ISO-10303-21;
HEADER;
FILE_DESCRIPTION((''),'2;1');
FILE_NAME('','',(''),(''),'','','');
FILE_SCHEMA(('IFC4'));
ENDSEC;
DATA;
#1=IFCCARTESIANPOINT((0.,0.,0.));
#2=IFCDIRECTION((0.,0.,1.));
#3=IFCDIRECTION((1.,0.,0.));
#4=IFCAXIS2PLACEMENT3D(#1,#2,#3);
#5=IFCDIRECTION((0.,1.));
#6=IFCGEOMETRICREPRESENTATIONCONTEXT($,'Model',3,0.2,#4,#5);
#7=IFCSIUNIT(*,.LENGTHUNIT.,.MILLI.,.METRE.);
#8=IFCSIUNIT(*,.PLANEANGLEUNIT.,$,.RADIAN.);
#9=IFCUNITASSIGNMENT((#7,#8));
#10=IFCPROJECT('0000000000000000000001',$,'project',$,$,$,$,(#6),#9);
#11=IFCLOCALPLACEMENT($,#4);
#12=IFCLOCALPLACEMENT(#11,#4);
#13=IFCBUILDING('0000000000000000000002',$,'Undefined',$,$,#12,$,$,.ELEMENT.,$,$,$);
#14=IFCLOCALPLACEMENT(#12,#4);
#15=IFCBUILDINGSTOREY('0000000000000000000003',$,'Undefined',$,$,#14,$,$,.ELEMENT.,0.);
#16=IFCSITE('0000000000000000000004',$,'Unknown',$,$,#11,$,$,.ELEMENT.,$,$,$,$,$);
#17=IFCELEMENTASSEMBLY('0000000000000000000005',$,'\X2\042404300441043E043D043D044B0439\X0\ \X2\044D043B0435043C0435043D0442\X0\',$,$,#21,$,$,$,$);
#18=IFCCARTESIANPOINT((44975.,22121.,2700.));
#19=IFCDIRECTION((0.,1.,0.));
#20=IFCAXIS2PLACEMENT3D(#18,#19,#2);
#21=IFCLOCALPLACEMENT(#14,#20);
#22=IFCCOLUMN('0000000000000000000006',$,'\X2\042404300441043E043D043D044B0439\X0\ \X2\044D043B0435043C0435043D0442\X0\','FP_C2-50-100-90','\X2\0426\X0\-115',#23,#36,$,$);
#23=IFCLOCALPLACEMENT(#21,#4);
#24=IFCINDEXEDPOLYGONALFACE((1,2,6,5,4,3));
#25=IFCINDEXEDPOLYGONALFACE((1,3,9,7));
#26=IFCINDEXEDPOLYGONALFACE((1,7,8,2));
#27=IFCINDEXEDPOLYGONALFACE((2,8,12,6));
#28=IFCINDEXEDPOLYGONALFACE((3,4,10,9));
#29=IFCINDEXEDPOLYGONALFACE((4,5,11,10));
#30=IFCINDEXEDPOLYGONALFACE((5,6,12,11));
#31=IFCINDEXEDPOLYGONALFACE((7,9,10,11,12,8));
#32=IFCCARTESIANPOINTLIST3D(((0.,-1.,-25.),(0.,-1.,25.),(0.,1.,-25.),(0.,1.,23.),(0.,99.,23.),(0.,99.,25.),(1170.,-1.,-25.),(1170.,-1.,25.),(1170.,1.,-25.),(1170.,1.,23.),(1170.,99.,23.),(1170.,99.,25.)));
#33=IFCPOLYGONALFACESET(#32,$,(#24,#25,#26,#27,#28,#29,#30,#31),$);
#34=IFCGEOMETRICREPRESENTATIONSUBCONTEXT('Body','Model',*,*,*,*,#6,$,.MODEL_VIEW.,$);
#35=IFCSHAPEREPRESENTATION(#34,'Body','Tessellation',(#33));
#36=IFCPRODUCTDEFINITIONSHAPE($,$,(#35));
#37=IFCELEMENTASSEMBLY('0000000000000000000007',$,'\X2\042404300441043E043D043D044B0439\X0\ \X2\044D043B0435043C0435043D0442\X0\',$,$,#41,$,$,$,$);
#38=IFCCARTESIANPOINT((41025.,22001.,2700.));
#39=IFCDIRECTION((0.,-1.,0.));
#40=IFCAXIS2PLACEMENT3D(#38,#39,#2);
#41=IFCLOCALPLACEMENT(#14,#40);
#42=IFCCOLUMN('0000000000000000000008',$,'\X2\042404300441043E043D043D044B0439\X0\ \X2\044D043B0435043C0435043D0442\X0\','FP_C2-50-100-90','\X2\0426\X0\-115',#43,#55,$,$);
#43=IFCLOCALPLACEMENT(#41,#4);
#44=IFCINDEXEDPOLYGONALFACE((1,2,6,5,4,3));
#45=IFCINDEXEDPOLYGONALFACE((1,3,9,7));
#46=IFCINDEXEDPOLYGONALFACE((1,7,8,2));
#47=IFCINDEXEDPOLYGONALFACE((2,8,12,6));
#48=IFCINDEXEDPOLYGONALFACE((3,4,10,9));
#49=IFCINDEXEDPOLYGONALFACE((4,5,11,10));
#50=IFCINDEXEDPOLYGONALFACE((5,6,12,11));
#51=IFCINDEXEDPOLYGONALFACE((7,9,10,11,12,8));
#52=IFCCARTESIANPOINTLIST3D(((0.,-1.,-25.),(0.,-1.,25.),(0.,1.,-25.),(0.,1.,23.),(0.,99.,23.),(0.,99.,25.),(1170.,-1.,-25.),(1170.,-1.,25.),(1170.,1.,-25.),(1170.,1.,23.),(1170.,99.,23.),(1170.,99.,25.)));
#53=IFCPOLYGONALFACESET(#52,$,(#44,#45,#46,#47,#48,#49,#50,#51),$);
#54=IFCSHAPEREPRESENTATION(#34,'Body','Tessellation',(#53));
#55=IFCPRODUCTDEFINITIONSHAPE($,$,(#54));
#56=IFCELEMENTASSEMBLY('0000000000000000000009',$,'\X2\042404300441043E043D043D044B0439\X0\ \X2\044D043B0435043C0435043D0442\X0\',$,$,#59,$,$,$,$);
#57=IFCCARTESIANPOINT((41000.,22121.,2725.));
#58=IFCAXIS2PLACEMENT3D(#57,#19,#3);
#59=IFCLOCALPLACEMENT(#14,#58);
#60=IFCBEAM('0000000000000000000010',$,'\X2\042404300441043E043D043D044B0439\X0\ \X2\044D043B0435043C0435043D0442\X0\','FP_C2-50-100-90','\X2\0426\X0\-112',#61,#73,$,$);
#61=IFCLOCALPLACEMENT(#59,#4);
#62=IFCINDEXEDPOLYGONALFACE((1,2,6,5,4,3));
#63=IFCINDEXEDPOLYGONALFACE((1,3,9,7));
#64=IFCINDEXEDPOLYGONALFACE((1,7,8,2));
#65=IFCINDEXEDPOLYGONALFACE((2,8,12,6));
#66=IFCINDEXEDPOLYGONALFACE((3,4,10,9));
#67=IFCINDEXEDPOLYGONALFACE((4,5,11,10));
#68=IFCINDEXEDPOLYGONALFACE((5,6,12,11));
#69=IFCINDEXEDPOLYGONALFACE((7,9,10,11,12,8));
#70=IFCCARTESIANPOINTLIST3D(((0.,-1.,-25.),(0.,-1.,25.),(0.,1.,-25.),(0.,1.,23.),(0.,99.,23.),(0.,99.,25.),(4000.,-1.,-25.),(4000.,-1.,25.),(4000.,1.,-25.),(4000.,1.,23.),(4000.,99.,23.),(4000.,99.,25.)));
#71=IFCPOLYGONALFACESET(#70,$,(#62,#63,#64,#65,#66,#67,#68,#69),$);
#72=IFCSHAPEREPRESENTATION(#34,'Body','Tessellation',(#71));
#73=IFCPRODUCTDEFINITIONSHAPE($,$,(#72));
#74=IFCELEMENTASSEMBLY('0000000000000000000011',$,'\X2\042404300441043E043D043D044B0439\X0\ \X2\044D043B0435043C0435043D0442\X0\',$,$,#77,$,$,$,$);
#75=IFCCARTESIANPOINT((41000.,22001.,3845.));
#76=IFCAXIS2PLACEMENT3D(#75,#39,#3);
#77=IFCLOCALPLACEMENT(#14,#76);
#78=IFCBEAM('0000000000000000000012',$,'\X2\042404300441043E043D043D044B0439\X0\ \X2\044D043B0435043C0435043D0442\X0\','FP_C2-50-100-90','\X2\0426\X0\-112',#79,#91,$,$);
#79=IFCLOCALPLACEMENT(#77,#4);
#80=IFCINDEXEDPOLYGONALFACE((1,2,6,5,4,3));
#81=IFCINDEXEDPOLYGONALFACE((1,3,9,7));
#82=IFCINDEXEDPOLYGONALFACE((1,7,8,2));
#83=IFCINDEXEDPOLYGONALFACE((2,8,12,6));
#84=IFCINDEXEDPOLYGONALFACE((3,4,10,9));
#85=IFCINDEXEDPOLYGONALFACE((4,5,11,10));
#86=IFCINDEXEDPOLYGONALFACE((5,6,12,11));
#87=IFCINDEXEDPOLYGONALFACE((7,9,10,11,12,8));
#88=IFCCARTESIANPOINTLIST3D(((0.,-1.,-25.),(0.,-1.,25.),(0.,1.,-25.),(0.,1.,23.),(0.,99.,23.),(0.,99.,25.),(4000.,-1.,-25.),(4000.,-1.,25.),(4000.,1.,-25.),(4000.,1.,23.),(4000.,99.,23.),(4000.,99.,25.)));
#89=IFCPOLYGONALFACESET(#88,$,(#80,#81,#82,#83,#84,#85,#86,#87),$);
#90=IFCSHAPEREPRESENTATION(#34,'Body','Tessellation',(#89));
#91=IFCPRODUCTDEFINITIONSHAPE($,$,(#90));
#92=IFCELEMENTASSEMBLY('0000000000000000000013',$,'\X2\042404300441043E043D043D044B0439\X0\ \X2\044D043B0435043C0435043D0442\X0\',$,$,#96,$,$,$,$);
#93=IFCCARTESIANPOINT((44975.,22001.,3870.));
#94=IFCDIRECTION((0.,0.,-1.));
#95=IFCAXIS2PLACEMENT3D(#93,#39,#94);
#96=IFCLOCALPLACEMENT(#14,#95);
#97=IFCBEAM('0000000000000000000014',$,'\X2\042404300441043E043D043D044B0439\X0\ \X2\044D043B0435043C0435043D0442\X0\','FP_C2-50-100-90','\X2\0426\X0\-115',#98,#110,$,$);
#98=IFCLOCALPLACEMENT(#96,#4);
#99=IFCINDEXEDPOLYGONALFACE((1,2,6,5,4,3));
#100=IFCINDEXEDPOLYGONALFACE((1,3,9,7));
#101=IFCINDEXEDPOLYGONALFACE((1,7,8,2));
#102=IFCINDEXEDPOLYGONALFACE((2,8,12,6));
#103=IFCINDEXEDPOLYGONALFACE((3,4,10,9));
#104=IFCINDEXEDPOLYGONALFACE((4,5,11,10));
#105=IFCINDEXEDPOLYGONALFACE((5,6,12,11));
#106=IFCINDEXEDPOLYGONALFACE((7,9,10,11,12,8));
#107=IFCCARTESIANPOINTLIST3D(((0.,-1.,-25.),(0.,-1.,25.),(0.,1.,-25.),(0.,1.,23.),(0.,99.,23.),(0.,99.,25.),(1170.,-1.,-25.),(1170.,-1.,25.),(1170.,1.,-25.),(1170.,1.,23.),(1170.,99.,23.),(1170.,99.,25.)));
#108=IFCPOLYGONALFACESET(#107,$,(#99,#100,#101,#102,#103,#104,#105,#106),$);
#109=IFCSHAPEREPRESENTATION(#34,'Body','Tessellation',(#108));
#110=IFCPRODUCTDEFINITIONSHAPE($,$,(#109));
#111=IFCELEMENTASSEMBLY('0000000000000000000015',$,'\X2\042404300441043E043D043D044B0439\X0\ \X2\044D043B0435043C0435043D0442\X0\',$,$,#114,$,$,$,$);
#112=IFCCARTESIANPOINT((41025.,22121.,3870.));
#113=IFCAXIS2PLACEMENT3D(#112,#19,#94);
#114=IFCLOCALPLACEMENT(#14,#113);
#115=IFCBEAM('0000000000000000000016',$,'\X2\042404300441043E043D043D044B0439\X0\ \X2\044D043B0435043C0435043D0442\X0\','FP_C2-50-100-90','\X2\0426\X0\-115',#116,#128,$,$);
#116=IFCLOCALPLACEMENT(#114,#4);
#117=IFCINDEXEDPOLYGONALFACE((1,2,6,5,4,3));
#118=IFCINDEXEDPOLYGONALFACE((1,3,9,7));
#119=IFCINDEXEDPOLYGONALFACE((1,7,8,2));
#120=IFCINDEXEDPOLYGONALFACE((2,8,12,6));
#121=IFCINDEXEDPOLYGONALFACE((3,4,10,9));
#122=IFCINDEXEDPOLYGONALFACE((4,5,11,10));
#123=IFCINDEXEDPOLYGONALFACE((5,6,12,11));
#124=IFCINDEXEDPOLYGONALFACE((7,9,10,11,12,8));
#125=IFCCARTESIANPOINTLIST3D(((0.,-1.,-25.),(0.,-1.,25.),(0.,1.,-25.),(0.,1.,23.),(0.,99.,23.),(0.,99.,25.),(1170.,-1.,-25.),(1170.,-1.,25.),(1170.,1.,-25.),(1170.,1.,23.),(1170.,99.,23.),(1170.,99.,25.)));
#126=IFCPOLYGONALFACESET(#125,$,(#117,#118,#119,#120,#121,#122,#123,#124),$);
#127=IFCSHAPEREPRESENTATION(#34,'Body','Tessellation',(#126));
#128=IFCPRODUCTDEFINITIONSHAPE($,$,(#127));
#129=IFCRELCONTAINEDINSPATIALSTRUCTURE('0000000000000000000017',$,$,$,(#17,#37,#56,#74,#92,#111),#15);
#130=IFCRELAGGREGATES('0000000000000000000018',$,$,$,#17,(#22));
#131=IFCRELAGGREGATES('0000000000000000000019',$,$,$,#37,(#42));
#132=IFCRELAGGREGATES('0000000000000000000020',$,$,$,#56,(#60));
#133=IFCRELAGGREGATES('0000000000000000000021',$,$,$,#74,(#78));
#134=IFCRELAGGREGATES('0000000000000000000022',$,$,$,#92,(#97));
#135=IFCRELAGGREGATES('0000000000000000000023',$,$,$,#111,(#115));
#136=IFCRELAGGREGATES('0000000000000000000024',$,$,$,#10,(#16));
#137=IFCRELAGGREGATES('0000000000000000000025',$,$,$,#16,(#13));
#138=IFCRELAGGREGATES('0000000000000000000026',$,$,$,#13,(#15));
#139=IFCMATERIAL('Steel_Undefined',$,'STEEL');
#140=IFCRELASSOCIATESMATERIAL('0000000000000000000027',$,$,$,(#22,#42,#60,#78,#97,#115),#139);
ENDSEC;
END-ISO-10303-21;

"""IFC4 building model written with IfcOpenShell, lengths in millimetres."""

from ifc_helpers import new_model, si_unit, direction, frame, origin_with_axes, place, context, subcontext, project, spatial, line, indexed_curve, outline, extrude, material, element, aggregate, save


model = new_model("IFC4")

# Units and contexts
model_context = context("Model", 3, precision=0.2, world=origin_with_axes(), true_north=direction((0.0, 1.0)))
body_context = subcontext(model_context, "Body", "Model", "MODEL_VIEW")
ifc_project = project(units=[si_unit("LENGTHUNIT", "METRE", prefix="MILLI"), si_unit("PLANEANGLEUNIT", "RADIAN")], contexts=[model_context])

# Site, building, storey
site_placement = place(None, origin_with_axes())
site = spatial("IfcSite", under=ifc_project, at=site_placement, Name="Unknown", CompositionType="ELEMENT")
building_placement = place(site_placement, origin_with_axes())
building = spatial("IfcBuilding", under=site, at=building_placement, Name="Undefined", CompositionType="ELEMENT")
storey_placement = place(building_placement, origin_with_axes())
storey = spatial("IfcBuildingStorey", under=building, at=storey_placement, Name="Undefined", CompositionType="ELEMENT", Elevation=0.0)

# Element assemblies, columns
assembly_1_placement = place(storey_placement, frame((44975.0, 22121.0, 2700.0), z_axis=(0.0, 1.0, 0.0), x_axis=(0.0, 0.0, 1.0)))
assembly_1 = element("IfcElementAssembly", 1, at=assembly_1_placement, inside=storey, Name="Фасонный элемент")
ifc_material_1 = material(Name="Steel_Undefined", Category="STEEL")
column_1_placement = place(assembly_1_placement, origin_with_axes())
column_1 = element("IfcColumn", 2, at=column_1_placement, material=ifc_material_1, Name="Фасонный элемент", Description="FP_C2-50-100-90", ObjectType="Ц-115", context=body_context, shape_type="SolidModel", body=[
    extrude(outline(indexed_curve([(-25.0, -1.0), (25.0, -1.0), (25.0, 99.0), (23.0, 99.0), (23.0, 1.0), (-25.0, 1.0)], segments=[line(1, 2, 3, 4, 5, 6, 1)])), frame((0.0, 0.0, 0.0), z_axis=(-1.0, 0.0, 0.0), x_axis=(0.0, 0.0, 1.0)), (0.0, 0.0, -1.0), 1170.0),
])
aggregate(assembly_1, [column_1])
assembly_2_placement = place(storey_placement, frame((41025.0, 22001.0, 2700.0), z_axis=(0.0, -1.0, 0.0), x_axis=(0.0, 0.0, 1.0)))
assembly_2 = element("IfcElementAssembly", 3, at=assembly_2_placement, inside=storey, Name="Фасонный элемент")
column_2_placement = place(assembly_2_placement, origin_with_axes())
column_2 = element("IfcColumn", 4, at=column_2_placement, material=ifc_material_1, Name="Фасонный элемент", Description="FP_C2-50-100-90", ObjectType="Ц-115", context=body_context, shape_type="SolidModel", body=[
    extrude(outline(indexed_curve([(-25.0, -1.0), (25.0, -1.0), (25.0, 99.0), (23.0, 99.0), (23.0, 1.0), (-25.0, 1.0)], segments=[line(1, 2, 3, 4, 5, 6, 1)])), frame((0.0, 0.0, 0.0), z_axis=(-1.0, 0.0, 0.0), x_axis=(0.0, 0.0, 1.0)), (0.0, 0.0, -1.0), 1170.0),
])
aggregate(assembly_2, [column_2])

# Element assemblies, beams
assembly_3_placement = place(storey_placement, frame((41000.0, 22121.0, 2725.0), z_axis=(0.0, 1.0, 0.0), x_axis=(1.0, 0.0, 0.0)))
assembly_3 = element("IfcElementAssembly", 5, at=assembly_3_placement, inside=storey, Name="Фасонный элемент")
beam_1_placement = place(assembly_3_placement, origin_with_axes())
beam_1 = element("IfcBeam", 6, at=beam_1_placement, material=ifc_material_1, Name="Фасонный элемент", Description="FP_C2-50-100-90", ObjectType="Ц-112", context=body_context, shape_type="SolidModel", body=[
    extrude(outline(indexed_curve([(-25.0, -1.0), (25.0, -1.0), (25.0, 99.0), (23.0, 99.0), (23.0, 1.0), (-25.0, 1.0)], segments=[line(1, 2, 3, 4, 5, 6, 1)])), frame((0.0, 0.0, 0.0), z_axis=(-1.0, 0.0, 0.0), x_axis=(0.0, 0.0, 1.0)), (0.0, 0.0, -1.0), 4000.0),
])
aggregate(assembly_3, [beam_1])
assembly_4_placement = place(storey_placement, frame((41000.0, 22001.0, 3845.0), z_axis=(0.0, -1.0, 0.0), x_axis=(1.0, 0.0, 0.0)))
assembly_4 = element("IfcElementAssembly", 7, at=assembly_4_placement, inside=storey, Name="Фасонный элемент")
beam_2_placement = place(assembly_4_placement, origin_with_axes())
beam_2 = element("IfcBeam", 8, at=beam_2_placement, material=ifc_material_1, Name="Фасонный элемент", Description="FP_C2-50-100-90", ObjectType="Ц-112", context=body_context, shape_type="SolidModel", body=[
    extrude(outline(indexed_curve([(-25.0, -1.0), (25.0, -1.0), (25.0, 99.0), (23.0, 99.0), (23.0, 1.0), (-25.0, 1.0)], segments=[line(1, 2, 3, 4, 5, 6, 1)])), frame((0.0, 0.0, 0.0), z_axis=(-1.0, 0.0, 0.0), x_axis=(0.0, 0.0, 1.0)), (0.0, 0.0, -1.0), 4000.0),
])
aggregate(assembly_4, [beam_2])
assembly_5_placement = place(storey_placement, frame((44975.0, 22001.0, 3870.0), z_axis=(0.0, -1.0, 0.0), x_axis=(0.0, 0.0, -1.0)))
assembly_5 = element("IfcElementAssembly", 9, at=assembly_5_placement, inside=storey, Name="Фасонный элемент")
beam_3_placement = place(assembly_5_placement, origin_with_axes())
beam_3 = element("IfcBeam", 10, at=beam_3_placement, material=ifc_material_1, Name="Фасонный элемент", Description="FP_C2-50-100-90", ObjectType="Ц-115", context=body_context, shape_type="SolidModel", body=[
    extrude(outline(indexed_curve([(-25.0, -1.0), (25.0, -1.0), (25.0, 99.0), (23.0, 99.0), (23.0, 1.0), (-25.0, 1.0)], segments=[line(1, 2, 3, 4, 5, 6, 1)])), frame((0.0, 0.0, 0.0), z_axis=(-1.0, 0.0, 0.0), x_axis=(0.0, 0.0, 1.0)), (0.0, 0.0, -1.0), 1170.0),
])
aggregate(assembly_5, [beam_3])
assembly_6_placement = place(storey_placement, frame((41025.0, 22121.0, 3870.0), z_axis=(0.0, 1.0, 0.0), x_axis=(0.0, 0.0, -1.0)))
assembly_6 = element("IfcElementAssembly", 11, at=assembly_6_placement, inside=storey, Name="Фасонный элемент")
beam_4_placement = place(assembly_6_placement, origin_with_axes())
beam_4 = element("IfcBeam", 12, at=beam_4_placement, material=ifc_material_1, Name="Фасонный элемент", Description="FP_C2-50-100-90", ObjectType="Ц-115", context=body_context, shape_type="SolidModel", body=[
    extrude(outline(indexed_curve([(-25.0, -1.0), (25.0, -1.0), (25.0, 99.0), (23.0, 99.0), (23.0, 1.0), (-25.0, 1.0)], segments=[line(1, 2, 3, 4, 5, 6, 1)])), frame((0.0, 0.0, 0.0), z_axis=(-1.0, 0.0, 0.0), x_axis=(0.0, 0.0, 1.0)), (0.0, 0.0, -1.0), 1170.0),
])
aggregate(assembly_6, [beam_4])

save(model, "model.ifc")
